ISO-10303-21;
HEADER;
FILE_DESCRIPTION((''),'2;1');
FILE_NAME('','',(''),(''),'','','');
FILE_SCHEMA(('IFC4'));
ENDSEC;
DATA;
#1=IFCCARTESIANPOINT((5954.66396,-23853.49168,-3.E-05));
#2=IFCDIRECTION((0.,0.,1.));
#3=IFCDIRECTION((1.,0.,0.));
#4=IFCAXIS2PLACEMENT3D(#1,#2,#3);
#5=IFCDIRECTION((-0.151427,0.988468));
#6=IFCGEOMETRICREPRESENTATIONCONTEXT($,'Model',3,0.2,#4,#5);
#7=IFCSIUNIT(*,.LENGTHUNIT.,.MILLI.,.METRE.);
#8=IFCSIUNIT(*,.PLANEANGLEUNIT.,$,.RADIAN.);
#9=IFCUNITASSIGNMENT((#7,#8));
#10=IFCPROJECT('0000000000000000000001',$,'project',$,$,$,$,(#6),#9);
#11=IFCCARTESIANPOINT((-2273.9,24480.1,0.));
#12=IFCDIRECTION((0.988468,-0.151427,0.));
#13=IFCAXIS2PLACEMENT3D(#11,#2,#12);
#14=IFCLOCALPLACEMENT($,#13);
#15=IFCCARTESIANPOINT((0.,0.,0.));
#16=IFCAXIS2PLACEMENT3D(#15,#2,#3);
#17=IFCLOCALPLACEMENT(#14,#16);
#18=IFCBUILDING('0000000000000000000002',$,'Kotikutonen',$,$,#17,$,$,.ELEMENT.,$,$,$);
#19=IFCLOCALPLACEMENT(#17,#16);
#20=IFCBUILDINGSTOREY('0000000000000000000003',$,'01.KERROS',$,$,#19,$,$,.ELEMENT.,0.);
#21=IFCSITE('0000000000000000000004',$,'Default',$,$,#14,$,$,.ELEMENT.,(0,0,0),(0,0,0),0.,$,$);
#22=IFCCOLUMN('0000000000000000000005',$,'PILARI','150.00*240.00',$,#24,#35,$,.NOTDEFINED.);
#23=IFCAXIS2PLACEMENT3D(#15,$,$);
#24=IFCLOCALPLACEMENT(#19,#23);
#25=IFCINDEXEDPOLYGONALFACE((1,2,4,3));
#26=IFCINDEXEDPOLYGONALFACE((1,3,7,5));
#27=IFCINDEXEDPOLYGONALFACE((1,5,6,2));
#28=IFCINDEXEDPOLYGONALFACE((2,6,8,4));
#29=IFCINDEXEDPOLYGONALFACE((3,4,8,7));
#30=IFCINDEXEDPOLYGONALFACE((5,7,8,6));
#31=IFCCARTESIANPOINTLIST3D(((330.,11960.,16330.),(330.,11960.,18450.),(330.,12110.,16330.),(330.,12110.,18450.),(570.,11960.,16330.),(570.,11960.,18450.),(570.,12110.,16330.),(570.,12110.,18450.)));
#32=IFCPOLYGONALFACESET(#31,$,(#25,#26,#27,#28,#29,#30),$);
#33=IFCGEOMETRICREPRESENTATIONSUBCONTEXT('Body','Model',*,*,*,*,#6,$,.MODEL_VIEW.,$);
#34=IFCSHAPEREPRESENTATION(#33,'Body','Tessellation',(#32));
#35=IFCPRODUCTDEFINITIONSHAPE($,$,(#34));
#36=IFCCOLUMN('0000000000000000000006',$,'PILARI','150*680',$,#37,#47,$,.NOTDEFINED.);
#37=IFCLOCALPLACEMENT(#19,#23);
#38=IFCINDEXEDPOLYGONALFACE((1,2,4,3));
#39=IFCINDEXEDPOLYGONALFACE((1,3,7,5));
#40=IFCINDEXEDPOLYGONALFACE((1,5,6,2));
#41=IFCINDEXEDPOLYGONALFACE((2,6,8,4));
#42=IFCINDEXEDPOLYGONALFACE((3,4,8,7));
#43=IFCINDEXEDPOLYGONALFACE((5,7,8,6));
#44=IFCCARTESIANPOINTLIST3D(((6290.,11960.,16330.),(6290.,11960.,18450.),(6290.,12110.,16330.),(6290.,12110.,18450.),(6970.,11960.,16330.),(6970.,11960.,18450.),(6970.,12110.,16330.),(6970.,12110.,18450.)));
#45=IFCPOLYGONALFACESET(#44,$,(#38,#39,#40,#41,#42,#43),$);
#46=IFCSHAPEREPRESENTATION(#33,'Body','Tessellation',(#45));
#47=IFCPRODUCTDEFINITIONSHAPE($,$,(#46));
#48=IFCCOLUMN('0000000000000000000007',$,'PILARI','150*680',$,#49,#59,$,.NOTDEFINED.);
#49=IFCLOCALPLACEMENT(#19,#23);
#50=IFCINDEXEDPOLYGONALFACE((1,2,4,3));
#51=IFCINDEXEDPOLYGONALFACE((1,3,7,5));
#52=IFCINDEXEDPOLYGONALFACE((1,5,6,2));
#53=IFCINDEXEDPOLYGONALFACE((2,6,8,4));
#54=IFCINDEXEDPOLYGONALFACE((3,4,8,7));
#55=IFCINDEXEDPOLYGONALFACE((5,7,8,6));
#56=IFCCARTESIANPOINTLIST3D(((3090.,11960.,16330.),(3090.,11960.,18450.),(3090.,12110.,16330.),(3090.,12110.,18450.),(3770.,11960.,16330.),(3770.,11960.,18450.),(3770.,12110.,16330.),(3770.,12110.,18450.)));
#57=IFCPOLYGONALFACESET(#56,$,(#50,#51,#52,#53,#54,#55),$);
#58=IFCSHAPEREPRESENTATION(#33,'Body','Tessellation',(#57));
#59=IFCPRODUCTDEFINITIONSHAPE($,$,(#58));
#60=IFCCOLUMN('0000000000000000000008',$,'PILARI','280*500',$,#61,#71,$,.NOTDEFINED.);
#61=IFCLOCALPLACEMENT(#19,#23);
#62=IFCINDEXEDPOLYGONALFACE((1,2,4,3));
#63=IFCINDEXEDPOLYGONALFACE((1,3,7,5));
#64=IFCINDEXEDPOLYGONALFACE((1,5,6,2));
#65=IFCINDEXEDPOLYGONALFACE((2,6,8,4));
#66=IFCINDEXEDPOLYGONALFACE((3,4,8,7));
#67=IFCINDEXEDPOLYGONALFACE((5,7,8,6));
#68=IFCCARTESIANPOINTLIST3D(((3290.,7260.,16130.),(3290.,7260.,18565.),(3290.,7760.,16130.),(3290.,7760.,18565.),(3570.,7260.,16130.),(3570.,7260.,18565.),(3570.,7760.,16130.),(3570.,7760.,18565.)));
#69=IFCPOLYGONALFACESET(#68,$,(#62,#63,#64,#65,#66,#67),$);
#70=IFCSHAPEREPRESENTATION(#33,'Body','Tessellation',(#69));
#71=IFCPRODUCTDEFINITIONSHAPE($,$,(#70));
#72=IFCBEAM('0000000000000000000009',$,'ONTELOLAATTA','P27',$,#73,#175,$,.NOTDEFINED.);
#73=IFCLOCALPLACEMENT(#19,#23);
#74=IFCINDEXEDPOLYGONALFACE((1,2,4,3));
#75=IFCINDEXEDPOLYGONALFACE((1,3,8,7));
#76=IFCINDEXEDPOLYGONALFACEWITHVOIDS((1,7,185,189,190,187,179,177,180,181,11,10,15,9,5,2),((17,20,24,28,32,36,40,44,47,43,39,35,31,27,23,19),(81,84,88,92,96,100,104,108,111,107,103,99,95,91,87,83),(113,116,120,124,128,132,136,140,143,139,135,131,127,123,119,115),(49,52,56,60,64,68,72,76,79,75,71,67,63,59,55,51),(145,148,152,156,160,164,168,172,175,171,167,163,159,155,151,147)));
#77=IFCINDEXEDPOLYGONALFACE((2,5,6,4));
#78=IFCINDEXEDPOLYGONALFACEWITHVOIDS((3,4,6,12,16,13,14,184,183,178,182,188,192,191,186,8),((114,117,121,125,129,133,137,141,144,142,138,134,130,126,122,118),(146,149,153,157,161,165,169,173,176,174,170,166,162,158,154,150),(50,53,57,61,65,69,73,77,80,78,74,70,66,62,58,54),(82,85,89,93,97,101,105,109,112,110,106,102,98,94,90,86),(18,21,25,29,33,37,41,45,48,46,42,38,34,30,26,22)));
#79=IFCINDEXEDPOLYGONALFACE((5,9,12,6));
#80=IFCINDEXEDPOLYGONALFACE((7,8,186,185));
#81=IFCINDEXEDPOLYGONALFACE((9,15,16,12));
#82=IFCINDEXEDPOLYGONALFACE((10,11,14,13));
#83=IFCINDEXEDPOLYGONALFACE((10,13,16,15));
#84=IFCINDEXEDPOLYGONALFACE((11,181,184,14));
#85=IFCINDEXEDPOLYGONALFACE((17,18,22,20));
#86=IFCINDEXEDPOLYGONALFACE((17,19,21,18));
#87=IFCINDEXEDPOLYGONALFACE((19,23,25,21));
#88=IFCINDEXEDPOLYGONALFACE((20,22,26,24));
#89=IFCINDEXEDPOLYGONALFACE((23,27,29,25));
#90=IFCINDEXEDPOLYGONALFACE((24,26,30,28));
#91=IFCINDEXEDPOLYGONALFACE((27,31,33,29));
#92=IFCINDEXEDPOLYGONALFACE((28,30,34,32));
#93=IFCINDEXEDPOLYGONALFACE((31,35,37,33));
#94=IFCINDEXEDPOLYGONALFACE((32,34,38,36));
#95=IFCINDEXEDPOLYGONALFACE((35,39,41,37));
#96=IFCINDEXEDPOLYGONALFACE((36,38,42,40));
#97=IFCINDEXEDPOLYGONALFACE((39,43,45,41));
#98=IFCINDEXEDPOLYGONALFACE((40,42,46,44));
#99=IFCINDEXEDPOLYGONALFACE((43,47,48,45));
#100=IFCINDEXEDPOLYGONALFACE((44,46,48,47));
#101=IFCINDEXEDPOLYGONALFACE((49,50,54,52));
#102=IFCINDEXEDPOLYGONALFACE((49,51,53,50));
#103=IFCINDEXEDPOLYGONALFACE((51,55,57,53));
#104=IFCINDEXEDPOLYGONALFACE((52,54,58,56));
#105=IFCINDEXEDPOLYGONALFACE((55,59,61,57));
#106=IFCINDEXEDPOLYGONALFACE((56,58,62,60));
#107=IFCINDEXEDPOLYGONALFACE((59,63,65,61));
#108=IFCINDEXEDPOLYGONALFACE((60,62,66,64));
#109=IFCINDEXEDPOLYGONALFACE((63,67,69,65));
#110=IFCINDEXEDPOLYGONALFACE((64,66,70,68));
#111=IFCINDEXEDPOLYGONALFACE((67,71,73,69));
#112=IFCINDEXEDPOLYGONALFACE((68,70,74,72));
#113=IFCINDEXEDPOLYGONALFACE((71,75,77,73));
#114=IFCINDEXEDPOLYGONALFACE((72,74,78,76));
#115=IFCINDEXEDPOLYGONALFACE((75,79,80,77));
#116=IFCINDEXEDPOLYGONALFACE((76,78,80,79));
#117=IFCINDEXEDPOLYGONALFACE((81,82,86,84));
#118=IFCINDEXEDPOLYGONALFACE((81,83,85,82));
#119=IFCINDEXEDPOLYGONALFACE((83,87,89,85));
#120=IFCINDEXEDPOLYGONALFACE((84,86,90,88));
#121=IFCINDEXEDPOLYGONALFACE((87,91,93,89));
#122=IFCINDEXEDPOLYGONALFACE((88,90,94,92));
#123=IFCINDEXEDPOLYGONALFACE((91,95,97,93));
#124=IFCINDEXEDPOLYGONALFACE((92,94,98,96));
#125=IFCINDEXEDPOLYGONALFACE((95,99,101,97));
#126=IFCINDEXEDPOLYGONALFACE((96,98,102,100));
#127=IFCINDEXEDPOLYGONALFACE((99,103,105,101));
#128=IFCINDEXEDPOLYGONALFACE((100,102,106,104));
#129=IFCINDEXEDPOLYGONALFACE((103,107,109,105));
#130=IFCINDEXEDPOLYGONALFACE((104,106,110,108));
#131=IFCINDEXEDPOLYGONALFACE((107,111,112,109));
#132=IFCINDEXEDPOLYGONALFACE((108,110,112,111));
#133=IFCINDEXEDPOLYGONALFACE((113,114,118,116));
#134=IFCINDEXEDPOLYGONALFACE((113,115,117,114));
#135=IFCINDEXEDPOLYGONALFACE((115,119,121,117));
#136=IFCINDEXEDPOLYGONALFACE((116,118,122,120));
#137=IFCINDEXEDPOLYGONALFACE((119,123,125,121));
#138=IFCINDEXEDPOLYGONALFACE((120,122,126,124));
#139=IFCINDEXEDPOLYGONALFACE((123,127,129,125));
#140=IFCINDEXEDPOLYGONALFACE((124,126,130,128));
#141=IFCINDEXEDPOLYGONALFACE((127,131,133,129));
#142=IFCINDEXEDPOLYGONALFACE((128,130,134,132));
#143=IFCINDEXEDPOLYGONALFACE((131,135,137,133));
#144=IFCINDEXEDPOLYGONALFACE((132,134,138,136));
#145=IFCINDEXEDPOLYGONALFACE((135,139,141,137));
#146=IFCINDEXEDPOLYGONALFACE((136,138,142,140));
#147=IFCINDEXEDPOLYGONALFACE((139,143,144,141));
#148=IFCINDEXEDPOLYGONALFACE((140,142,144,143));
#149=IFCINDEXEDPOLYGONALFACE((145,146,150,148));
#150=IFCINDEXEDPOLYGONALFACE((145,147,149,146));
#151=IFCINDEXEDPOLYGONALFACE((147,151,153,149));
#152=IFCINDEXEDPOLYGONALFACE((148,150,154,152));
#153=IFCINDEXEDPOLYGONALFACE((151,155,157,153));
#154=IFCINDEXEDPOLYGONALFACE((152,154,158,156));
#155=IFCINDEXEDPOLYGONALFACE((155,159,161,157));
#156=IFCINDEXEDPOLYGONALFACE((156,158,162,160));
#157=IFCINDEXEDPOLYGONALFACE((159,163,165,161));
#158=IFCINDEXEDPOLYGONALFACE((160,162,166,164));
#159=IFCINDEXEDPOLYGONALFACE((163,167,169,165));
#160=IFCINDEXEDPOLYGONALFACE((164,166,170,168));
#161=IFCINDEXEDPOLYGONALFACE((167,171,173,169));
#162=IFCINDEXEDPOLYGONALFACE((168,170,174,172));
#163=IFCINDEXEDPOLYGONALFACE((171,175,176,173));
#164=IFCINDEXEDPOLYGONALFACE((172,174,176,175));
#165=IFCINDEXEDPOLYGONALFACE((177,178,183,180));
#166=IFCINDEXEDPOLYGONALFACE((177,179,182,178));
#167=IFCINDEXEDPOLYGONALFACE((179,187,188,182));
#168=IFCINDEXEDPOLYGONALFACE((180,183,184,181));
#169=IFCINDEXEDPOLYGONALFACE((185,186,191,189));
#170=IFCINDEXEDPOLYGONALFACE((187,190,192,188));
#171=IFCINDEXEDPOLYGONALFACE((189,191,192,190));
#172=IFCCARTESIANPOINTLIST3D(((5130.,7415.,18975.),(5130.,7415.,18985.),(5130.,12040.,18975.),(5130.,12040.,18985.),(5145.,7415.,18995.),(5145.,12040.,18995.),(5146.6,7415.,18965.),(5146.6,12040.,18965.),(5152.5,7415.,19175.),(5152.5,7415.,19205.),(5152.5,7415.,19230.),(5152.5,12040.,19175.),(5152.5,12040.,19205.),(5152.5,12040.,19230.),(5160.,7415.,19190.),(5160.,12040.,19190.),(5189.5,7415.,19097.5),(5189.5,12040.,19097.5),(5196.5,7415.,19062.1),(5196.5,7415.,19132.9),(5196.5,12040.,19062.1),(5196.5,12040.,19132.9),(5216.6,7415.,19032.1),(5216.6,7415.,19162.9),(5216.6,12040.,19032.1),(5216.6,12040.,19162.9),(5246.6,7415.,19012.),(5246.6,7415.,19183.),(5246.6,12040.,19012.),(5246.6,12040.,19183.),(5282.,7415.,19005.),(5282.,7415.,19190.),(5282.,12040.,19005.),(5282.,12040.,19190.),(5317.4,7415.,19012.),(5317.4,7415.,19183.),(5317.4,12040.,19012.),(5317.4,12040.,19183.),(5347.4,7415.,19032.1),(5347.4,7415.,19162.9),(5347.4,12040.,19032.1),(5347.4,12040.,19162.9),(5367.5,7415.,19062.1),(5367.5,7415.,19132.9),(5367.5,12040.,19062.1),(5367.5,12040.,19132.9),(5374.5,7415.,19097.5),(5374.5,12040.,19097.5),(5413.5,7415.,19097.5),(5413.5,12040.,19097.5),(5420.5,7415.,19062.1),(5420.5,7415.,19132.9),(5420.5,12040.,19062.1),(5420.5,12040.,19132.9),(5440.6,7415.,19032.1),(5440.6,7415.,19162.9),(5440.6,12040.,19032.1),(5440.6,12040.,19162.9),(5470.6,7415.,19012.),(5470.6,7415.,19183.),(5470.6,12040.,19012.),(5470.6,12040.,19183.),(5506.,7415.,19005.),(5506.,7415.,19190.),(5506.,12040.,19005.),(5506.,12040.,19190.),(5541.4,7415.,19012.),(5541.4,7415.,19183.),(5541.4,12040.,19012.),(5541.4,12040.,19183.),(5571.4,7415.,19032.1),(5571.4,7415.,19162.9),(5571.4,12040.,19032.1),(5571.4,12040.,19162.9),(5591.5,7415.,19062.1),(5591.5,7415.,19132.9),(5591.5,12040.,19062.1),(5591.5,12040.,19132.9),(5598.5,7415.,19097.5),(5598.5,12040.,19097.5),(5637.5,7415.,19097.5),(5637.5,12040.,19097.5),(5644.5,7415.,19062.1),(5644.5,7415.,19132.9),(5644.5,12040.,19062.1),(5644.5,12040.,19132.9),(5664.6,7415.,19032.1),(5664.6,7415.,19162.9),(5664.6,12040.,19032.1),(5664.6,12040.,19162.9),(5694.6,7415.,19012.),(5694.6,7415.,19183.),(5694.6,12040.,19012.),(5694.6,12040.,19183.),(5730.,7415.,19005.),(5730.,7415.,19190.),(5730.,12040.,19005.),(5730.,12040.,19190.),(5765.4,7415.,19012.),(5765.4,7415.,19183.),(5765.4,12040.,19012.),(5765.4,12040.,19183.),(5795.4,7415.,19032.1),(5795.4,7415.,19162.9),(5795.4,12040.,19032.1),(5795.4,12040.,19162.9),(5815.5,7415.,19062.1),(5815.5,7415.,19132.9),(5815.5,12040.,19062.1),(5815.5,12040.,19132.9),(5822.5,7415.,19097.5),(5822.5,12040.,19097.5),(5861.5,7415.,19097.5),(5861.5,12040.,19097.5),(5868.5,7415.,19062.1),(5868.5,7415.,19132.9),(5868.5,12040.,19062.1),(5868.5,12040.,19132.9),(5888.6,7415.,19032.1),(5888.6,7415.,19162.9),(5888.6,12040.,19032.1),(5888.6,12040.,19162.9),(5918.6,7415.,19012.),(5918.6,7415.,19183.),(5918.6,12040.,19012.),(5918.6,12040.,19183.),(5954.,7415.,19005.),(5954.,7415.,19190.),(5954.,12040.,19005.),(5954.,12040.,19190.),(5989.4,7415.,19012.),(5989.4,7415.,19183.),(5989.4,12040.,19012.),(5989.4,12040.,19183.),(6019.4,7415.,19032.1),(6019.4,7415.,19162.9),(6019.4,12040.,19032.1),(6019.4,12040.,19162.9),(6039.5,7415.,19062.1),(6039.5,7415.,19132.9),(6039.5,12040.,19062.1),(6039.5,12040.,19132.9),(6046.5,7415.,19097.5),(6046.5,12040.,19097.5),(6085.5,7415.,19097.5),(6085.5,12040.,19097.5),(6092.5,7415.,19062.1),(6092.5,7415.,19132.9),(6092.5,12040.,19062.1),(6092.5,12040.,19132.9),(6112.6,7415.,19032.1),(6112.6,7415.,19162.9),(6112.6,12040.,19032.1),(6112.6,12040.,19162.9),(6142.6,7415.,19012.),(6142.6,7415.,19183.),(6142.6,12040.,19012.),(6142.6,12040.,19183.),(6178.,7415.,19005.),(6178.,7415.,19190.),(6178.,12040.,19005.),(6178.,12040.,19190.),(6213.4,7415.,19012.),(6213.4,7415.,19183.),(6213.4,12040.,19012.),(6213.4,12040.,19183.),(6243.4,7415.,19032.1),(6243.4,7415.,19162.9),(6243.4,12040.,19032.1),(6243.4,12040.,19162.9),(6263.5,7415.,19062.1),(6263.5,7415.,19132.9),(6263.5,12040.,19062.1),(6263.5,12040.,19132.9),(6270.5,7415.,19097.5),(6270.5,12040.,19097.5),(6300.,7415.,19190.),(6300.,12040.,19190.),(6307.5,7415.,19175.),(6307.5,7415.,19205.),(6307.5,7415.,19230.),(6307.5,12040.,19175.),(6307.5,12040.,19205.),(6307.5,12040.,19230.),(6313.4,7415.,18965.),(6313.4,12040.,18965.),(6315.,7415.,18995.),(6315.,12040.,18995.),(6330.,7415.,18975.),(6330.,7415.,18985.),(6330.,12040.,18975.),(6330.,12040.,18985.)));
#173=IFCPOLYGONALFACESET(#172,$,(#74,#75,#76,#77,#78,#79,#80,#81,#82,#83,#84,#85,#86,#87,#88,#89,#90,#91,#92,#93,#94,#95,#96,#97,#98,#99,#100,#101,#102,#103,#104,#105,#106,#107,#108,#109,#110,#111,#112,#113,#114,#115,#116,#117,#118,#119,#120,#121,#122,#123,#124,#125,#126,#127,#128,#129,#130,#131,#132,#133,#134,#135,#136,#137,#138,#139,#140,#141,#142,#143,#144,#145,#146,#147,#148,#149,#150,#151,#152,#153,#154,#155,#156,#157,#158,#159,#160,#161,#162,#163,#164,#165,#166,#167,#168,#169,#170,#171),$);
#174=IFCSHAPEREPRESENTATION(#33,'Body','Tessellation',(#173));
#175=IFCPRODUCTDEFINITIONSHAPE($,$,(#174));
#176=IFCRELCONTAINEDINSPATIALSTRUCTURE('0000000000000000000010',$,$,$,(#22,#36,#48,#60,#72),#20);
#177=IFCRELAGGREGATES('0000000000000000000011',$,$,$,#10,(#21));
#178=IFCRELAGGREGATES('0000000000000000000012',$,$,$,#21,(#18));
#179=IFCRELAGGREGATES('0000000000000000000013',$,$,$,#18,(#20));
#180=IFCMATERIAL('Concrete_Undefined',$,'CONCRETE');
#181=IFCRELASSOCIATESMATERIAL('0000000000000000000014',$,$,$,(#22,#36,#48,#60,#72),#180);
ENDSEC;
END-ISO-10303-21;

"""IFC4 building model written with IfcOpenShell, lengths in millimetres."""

from ifc_helpers import new_model, si_unit, direction, frame, origin_with_axes, place, context, subcontext, project, spatial, line, indexed_curve, outline, extrude, material, element, save


model = new_model("IFC4")

# Units and contexts
model_context = context("Model", 3, precision=0.2, world=frame((5954.66396, -23853.49168, -3e-05), z_axis=(0.0, 0.0, 1.0), x_axis=(1.0, 0.0, 0.0)), true_north=direction((-0.151427, 0.988468)))
body_context = subcontext(model_context, "Body", "Model", "MODEL_VIEW")
ifc_project = project(units=[si_unit("LENGTHUNIT", "METRE", prefix="MILLI"), si_unit("PLANEANGLEUNIT", "RADIAN")], contexts=[model_context])

# Site, building, storey
site_placement = place(None, frame((-2273.9, 24480.1, 0.0), z_axis=(0.0, 0.0, 1.0), x_axis=(0.988468, -0.151427, 0.0)))
site = spatial("IfcSite", under=ifc_project, at=site_placement, Name="Default", CompositionType="ELEMENT", RefLatitude=(0, 0, 0), RefLongitude=(0, 0, 0), RefElevation=0.0)
building_placement = place(site_placement, origin_with_axes())
building = spatial("IfcBuilding", under=site, at=building_placement, Name="Kotikutonen", CompositionType="ELEMENT")
storey_placement = place(building_placement, origin_with_axes())
storey = spatial("IfcBuildingStorey", under=building, at=storey_placement, Name="01.KERROS", CompositionType="ELEMENT", Elevation=0.0)

# Columns
ifc_material_1 = material(Name="Concrete_Undefined", Category="CONCRETE")
column_1_placement = place(storey_placement, frame((450.0, 12035.0, 16330.0), z_axis=(1.0, 0.0, 0.0), x_axis=(0.0, 0.0, 1.0)))
element("IfcColumn", 1, at=column_1_placement, inside=storey, material=ifc_material_1, Name="PILARI", Description="150.00*240.00", PredefinedType="NOTDEFINED", context=body_context, shape_type="SolidModel", body=[
    extrude(outline(indexed_curve([(-120.0, -75.0), (120.0, -75.0), (120.0, 75.0), (-120.0, 75.0)], segments=[line(1, 2, 3, 4, 1)])), frame((0.0, 0.0, 0.0), z_axis=(-1.0, 0.0, 0.0), x_axis=(0.0, 0.0, 1.0)), (0.0, 0.0, -1.0), 2120.0),
])
for number, where, z_axis, x_axis, name in (
    (2, (6630.0, 12035.0, 16330.0), (1.0, 0.0, 0.0), (0.0, 0.0, 1.0), "PILARI"),
    (3, (3430.0, 12035.0, 16330.0), (1.0, 0.0, 0.0), (0.0, 0.0, 1.0), "PILARI"),
):
    element("IfcColumn", number, at=place(storey_placement, frame(where, z_axis=z_axis, x_axis=x_axis)), inside=storey, material=ifc_material_1, Name=name, Description="150*680", PredefinedType="NOTDEFINED", context=body_context, shape_type="SolidModel", body=[
        extrude(outline(indexed_curve([(-340.0, -75.0), (340.0, -75.0), (340.0, 75.0), (-340.0, 75.0)], segments=[line(1, 2, 3, 4, 1)])), frame((0.0, 0.0, 0.0), z_axis=(-1.0, 0.0, 0.0), x_axis=(0.0, 0.0, 1.0)), (0.0, 0.0, -1.0), 2120.0),
    ])
column_2_placement = place(storey_placement, frame((3430.0, 7510.0, 16130.0), z_axis=(0.0, -1.0, 0.0), x_axis=(0.0, 0.0, 1.0)))
element("IfcColumn", 4, at=column_2_placement, inside=storey, material=ifc_material_1, Name="PILARI", Description="280*500", PredefinedType="NOTDEFINED", context=body_context, shape_type="SolidModel", body=[
    extrude(outline(indexed_curve([(-250.0, -140.0), (250.0, -140.0), (250.0, 140.0), (-250.0, 140.0)], segments=[line(1, 2, 3, 4, 1)])), frame((0.0, 0.0, 0.0), z_axis=(-1.0, 0.0, 0.0), x_axis=(0.0, 0.0, 1.0)), (0.0, 0.0, -1.0), 2435.0),
])

# Beam
beam_1_placement = place(storey_placement, frame((5730.0, 12040.0, 19097.5), z_axis=(-1.0, 0.0, 0.0), x_axis=(0.0, -1.0, 0.0)))
element("IfcBeam", 5, at=beam_1_placement, inside=storey, material=ifc_material_1, Name="ONTELOLAATTA", Description="P27", PredefinedType="NOTDEFINED", context=body_context, shape_type="SolidModel", body=[
    extrude(outline(indexed_curve([(-600.0, -122.5), (-583.4, -132.5), (583.4, -132.5), (600.0, -122.5), (600.0, -112.5), (585.0, -102.5), (577.5, 77.5), (570.0, 92.5), (577.5, 107.5), (577.5, 132.5), (-577.5, 132.5), (-577.5, 107.5), (-570.0, 92.5), (-577.5, 77.5), (-585.0, -102.5), (-600.0, -112.5)], segments=[line(1, 2, 3, 4, 5, 6, 7, 8, 9, 10, 11, 12, 13, 14, 15, 16, 1)]), holes=[indexed_curve([(-448.0, -92.5), (-483.4, -85.5), (-513.4, -65.4), (-533.5, -35.4), (-540.5, 0.0), (-533.5, 35.4), (-513.4, 65.4), (-483.4, 85.5), (-448.0, 92.5), (-412.6, 85.5), (-382.6, 65.4), (-362.5, 35.4), (-355.5, 0.0), (-362.5, -35.4), (-382.6, -65.4), (-412.6, -85.5)], segments=[line(1, 2, 3, 4, 5, 6, 7, 8, 9, 10, 11, 12, 13, 14, 15, 16, 1)]), indexed_curve([(-224.0, -92.5), (-259.4, -85.5), (-289.4, -65.4), (-309.5, -35.4), (-316.5, 0.0), (-309.5, 35.4), (-289.4, 65.4), (-259.4, 85.5), (-224.0, 92.5), (-188.6, 85.5), (-158.6, 65.4), (-138.5, 35.4), (-131.5, 0.0), (-138.5, -35.4), (-158.6, -65.4), (-188.6, -85.5)], segments=[line(1, 2, 3, 4, 5, 6, 7, 8, 9, 10, 11, 12, 13, 14, 15, 16, 1)]), indexed_curve([(0.0, -92.5), (-35.4, -85.5), (-65.4, -65.4), (-85.5, -35.4), (-92.5, 0.0), (-85.5, 35.4), (-65.4, 65.4), (-35.4, 85.5), (0.0, 92.5), (35.4, 85.5), (65.4, 65.4), (85.5, 35.4), (92.5, 0.0), (85.5, -35.4), (65.4, -65.4), (35.4, -85.5)], segments=[line(1, 2, 3, 4, 5, 6, 7, 8, 9, 10, 11, 12, 13, 14, 15, 16, 1)]), indexed_curve([(224.0, -92.5), (188.6, -85.5), (158.6, -65.4), (138.5, -35.4), (131.5, 0.0), (138.5, 35.4), (158.6, 65.4), (188.6, 85.5), (224.0, 92.5), (259.4, 85.5), (289.4, 65.4), (309.5, 35.4), (316.5, 0.0), (309.5, -35.4), (289.4, -65.4), (259.4, -85.5)], segments=[line(1, 2, 3, 4, 5, 6, 7, 8, 9, 10, 11, 12, 13, 14, 15, 16, 1)]), indexed_curve([(448.0, -92.5), (412.6, -85.5), (382.6, -65.4), (362.5, -35.4), (355.5, 0.0), (362.5, 35.4), (382.6, 65.4), (412.6, 85.5), (448.0, 92.5), (483.4, 85.5), (513.4, 65.4), (533.5, 35.4), (540.5, 0.0), (533.5, -35.4), (513.4, -65.4), (483.4, -85.5)], segments=[line(1, 2, 3, 4, 5, 6, 7, 8, 9, 10, 11, 12, 13, 14, 15, 16, 1)])]), frame((0.0, 0.0, 0.0), z_axis=(-1.0, 0.0, 0.0), x_axis=(0.0, 0.0, 1.0)), (0.0, 0.0, -1.0), 4625.0),
])

save(model, "model.ifc")
